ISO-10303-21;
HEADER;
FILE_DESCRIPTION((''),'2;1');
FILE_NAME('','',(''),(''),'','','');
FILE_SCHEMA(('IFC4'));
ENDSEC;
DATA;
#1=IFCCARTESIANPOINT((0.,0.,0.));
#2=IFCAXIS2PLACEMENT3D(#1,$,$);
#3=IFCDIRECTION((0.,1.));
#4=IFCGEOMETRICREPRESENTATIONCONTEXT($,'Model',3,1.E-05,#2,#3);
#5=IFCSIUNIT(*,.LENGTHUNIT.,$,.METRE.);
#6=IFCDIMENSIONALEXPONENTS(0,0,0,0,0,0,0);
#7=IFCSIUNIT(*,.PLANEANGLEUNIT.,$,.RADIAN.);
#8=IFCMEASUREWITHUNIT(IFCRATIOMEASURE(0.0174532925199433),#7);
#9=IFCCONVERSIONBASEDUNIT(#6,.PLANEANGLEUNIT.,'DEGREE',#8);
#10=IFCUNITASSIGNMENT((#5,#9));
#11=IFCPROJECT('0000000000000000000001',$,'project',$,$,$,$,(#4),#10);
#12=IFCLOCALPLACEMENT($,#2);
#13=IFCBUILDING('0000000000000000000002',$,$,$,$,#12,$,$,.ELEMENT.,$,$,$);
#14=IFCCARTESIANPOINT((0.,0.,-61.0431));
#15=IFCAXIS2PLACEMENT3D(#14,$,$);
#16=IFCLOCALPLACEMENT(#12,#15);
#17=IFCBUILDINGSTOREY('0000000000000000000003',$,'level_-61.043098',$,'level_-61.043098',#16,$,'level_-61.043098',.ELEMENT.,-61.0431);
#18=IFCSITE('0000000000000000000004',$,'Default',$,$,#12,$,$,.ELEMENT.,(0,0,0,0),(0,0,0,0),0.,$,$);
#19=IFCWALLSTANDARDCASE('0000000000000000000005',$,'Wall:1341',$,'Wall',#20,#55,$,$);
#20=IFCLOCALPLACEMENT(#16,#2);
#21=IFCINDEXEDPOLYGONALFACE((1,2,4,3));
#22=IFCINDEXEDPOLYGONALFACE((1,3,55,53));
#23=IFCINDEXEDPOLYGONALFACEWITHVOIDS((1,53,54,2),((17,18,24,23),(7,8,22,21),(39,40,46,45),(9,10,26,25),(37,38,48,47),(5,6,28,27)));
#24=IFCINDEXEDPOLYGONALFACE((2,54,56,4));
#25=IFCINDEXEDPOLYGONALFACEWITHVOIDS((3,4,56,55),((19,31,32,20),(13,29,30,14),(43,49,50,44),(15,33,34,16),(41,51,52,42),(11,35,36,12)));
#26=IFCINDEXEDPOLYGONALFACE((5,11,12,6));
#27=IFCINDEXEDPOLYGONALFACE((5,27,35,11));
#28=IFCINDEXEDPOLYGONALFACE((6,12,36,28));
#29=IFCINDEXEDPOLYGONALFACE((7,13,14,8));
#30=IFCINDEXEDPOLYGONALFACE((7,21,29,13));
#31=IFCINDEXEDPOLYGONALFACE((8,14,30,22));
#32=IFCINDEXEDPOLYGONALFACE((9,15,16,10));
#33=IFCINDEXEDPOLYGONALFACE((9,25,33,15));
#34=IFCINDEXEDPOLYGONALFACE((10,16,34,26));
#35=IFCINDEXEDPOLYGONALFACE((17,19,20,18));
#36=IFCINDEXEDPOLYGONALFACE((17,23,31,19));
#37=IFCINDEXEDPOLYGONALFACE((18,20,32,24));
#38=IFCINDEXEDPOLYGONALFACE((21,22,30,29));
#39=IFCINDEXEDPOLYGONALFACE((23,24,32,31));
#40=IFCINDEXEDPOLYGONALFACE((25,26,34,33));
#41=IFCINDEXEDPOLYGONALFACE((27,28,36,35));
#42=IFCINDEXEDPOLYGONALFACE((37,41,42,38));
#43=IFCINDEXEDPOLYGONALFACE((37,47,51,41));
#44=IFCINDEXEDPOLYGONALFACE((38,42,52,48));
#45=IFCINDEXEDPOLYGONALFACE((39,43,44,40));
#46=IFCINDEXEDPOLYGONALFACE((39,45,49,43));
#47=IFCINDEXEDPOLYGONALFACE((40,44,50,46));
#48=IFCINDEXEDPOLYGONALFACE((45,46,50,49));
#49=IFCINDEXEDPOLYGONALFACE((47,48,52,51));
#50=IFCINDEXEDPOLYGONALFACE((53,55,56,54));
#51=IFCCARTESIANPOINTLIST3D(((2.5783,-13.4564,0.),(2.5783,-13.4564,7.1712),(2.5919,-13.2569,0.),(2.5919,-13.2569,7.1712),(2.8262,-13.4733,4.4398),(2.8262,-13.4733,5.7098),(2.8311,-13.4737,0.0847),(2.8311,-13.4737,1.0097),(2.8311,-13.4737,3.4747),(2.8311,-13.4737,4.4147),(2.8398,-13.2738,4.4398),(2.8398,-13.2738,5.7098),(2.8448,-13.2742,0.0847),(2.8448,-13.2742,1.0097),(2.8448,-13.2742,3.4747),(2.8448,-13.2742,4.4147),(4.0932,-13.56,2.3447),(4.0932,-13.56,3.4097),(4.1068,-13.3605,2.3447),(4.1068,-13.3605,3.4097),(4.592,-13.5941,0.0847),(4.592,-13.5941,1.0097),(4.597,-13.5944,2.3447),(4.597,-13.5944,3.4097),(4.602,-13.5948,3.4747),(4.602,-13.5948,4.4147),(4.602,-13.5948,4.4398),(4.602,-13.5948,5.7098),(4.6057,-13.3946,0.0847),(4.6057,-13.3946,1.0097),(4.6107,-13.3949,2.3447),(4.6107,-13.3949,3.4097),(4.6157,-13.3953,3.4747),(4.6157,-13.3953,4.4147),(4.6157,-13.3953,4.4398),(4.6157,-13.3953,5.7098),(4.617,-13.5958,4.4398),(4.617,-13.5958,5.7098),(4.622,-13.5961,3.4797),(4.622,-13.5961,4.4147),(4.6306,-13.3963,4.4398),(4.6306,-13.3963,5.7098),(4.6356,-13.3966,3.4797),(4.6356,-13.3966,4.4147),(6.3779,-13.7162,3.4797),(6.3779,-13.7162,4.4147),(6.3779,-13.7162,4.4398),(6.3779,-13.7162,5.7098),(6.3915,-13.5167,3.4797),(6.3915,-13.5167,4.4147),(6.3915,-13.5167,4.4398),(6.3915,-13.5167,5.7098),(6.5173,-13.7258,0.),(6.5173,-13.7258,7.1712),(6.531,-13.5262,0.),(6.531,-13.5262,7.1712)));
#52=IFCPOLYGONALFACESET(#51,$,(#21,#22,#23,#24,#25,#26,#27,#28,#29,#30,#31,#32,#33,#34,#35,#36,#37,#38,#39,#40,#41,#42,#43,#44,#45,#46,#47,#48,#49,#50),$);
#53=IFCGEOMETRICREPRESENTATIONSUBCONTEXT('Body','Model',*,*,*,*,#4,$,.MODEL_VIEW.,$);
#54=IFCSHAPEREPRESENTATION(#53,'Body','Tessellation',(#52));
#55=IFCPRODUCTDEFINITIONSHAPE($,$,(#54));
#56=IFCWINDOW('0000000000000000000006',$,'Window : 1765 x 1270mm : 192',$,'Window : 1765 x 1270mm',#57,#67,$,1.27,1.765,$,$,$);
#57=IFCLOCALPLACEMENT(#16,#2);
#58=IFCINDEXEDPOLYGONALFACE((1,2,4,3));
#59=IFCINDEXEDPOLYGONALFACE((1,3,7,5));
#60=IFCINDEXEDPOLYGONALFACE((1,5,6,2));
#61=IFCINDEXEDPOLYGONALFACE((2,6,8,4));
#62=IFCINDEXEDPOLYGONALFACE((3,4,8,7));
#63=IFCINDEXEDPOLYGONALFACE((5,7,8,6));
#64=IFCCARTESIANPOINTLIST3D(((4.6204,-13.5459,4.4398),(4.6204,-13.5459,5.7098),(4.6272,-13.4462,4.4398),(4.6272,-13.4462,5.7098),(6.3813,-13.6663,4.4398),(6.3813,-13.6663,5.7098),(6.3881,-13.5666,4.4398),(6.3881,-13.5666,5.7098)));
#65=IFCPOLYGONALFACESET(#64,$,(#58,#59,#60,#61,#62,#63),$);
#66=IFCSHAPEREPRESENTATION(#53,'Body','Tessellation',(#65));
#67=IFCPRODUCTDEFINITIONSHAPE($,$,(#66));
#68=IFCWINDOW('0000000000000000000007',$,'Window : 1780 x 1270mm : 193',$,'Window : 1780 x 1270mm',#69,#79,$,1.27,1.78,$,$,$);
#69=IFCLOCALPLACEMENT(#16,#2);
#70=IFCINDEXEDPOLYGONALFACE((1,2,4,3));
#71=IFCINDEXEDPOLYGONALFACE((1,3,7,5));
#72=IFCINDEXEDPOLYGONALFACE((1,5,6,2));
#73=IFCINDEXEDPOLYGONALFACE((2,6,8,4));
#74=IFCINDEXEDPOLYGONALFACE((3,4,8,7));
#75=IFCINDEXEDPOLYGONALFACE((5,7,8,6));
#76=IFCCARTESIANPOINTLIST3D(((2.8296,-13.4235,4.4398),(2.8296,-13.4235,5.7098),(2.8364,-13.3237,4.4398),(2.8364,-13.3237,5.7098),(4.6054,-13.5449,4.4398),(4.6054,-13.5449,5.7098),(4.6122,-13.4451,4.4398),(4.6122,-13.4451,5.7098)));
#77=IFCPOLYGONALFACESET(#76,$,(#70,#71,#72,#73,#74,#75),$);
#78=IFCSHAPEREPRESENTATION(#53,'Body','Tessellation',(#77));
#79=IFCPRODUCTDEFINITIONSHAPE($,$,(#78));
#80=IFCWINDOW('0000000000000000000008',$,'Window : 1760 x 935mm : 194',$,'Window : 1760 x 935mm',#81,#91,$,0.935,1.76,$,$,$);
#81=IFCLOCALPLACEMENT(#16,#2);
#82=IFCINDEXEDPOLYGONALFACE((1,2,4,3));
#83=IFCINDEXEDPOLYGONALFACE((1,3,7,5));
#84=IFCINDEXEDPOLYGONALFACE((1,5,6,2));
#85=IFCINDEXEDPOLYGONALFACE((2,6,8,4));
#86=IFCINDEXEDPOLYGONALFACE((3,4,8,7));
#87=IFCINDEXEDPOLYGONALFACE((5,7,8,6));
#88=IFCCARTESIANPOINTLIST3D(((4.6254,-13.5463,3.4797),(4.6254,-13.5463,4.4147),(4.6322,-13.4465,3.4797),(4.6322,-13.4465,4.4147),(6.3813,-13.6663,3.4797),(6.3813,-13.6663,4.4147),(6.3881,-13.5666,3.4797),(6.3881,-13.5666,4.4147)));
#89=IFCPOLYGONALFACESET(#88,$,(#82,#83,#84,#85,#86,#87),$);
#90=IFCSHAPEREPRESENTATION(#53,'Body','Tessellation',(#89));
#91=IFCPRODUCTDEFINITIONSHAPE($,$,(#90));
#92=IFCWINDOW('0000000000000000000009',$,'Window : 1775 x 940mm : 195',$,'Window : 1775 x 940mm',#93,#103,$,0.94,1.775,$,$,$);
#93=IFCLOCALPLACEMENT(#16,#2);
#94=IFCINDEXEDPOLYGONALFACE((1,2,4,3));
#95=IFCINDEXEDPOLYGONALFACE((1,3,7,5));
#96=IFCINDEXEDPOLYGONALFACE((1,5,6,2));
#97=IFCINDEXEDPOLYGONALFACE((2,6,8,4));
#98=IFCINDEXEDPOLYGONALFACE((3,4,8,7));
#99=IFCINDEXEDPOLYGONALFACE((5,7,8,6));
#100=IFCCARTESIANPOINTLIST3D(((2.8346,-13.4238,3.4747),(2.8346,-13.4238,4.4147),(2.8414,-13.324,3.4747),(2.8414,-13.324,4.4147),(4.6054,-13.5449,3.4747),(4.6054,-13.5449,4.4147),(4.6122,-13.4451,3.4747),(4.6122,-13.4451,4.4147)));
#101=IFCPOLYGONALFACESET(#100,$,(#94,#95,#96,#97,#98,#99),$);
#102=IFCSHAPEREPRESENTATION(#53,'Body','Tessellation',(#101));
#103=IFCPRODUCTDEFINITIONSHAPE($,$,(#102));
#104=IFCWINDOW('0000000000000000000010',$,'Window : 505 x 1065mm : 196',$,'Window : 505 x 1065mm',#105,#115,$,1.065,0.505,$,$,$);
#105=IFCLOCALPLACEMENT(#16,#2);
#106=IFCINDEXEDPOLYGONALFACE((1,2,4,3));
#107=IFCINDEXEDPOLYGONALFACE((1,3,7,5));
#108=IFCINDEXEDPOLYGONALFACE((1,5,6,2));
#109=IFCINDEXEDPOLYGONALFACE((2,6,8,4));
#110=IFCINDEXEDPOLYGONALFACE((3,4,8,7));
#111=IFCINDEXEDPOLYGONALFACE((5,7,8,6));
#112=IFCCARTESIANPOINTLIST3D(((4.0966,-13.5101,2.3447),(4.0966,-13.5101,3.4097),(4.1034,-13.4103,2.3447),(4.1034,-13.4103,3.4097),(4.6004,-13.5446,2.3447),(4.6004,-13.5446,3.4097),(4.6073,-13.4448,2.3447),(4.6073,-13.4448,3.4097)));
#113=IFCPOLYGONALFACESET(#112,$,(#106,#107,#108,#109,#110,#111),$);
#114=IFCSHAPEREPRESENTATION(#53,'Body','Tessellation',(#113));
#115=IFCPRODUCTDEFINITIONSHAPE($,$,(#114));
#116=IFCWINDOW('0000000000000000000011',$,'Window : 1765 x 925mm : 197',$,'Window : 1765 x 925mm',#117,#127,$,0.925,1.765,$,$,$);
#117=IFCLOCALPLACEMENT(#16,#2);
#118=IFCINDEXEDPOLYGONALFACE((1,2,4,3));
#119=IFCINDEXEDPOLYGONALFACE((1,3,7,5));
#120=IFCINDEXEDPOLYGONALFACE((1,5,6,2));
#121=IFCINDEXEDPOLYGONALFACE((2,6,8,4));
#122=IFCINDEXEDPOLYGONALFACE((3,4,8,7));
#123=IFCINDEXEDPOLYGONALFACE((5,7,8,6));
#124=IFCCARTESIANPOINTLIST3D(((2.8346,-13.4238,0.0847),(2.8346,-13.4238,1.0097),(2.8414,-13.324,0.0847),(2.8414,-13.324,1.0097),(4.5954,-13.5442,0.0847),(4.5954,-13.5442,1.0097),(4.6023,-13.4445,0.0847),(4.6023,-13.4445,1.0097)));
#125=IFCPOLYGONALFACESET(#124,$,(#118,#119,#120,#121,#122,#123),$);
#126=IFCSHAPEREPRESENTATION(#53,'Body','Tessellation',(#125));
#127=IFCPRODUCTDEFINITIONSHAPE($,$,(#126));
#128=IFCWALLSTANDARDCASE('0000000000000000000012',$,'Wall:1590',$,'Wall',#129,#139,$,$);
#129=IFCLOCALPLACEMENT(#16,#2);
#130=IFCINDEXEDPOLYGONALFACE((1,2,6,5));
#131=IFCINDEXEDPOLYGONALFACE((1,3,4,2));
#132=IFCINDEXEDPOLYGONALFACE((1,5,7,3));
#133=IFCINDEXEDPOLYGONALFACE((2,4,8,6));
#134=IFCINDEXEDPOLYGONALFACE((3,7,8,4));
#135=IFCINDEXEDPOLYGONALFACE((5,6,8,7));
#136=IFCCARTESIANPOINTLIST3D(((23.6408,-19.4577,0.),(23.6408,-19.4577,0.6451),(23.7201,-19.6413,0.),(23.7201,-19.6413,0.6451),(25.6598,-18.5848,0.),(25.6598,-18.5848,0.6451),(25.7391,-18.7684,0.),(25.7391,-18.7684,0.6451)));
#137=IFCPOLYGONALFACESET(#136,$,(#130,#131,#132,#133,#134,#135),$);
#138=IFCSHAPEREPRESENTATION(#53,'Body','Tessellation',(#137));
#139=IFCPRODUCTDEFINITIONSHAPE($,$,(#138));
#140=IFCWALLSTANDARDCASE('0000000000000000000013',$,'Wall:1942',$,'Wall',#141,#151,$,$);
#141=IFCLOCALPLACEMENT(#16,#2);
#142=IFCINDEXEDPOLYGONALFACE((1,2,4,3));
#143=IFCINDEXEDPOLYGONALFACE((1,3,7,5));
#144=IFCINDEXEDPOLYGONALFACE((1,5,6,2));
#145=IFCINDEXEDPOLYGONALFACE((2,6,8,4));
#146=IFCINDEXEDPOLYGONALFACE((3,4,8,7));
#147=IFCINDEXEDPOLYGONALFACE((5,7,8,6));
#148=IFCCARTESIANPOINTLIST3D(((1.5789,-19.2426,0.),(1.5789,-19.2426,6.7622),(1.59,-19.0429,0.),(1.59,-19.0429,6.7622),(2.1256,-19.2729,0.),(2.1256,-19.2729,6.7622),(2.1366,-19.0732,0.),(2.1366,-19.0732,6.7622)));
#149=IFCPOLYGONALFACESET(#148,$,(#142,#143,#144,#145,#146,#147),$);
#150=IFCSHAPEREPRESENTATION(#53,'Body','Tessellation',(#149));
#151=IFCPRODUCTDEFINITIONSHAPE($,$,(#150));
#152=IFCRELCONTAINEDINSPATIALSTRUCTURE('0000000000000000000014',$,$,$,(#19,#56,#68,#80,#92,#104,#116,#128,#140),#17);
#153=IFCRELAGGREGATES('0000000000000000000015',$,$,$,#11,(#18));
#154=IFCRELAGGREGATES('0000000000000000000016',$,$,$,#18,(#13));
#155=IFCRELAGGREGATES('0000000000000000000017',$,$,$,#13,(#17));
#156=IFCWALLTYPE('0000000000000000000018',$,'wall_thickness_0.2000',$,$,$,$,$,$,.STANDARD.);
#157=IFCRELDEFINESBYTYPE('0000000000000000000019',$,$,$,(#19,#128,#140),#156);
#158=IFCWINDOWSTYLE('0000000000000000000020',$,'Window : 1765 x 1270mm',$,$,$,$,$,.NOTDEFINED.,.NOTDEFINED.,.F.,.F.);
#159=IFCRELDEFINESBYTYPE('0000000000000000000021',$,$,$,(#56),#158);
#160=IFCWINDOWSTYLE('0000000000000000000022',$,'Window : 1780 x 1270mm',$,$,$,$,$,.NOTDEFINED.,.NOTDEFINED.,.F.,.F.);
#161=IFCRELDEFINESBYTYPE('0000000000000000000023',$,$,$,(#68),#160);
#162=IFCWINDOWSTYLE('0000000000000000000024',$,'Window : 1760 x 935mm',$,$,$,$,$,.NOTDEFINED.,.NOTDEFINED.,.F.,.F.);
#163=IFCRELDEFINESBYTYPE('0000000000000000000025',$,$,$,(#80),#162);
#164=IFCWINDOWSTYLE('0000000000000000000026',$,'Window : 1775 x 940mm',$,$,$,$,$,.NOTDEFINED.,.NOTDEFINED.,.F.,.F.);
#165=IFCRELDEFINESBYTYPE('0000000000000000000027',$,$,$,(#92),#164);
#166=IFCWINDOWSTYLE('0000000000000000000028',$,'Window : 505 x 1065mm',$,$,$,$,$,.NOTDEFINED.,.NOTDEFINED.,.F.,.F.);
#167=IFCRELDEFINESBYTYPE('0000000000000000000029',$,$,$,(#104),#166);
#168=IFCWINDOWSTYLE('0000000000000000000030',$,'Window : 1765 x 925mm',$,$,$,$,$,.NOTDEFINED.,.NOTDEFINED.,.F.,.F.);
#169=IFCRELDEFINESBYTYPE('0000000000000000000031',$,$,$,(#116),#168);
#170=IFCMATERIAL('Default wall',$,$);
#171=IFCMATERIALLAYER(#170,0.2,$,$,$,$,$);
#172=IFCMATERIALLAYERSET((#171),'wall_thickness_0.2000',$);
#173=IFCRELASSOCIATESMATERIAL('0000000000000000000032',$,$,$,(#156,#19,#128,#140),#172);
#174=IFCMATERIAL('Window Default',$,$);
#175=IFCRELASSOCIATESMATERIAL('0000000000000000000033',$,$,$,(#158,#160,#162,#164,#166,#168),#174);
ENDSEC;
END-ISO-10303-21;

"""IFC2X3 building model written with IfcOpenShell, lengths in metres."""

from ifc_helpers import new_model, entity, si_unit, converted_unit, direction, frame, frame_2d, origin, origin_2d_with_axis, place, context, subcontext, project, spatial, polyline, rectangle, outline, extrude, source, transform, mapped, material, layer, layer_set, layer_usage, type_object, type_shapes, element, fill, save


model = new_model("IFC2X3")

# Units and contexts
model_context = context("Model", 3, precision=1e-05, world=origin(), true_north=direction((0.0, 1.0)))
body_context = subcontext(model_context, "Body", "Model", "MODEL_VIEW")
ifc_project = project(units=[si_unit("LENGTHUNIT", "METRE"), converted_unit("PLANEANGLEUNIT", "DEGREE", entity("IfcRatioMeasure", 0.0174532925199433), si_unit("PLANEANGLEUNIT", "RADIAN"), dimensions=[0, 0, 0, 0, 0, 0, 0])], contexts=[model_context])

# Site, building, storey
placement_1 = place(None, origin())
site = spatial("IfcSite", under=ifc_project, at=placement_1, Name="Default", CompositionType="ELEMENT", RefLatitude=(0, 0, 0, 0), RefLongitude=(0, 0, 0, 0), RefElevation=0.0)
building = spatial("IfcBuilding", under=site, at=placement_1, CompositionType="ELEMENT")
storey_placement = place(placement_1, frame((0.0, 0.0, -61.0431)))
storey = spatial("IfcBuildingStorey", under=building, at=storey_placement, Name="level_-61.043098", ObjectType="level_-61.043098", LongName="level_-61.043098", CompositionType="ELEMENT", Elevation=-61.0431)

# Shared definitions
ifc_material_1 = material(Name="Default wall")
ifc_layer = layer(ifc_material_1, 0.2)
ifc_layer_set = layer_set([ifc_layer], Name="wall_thickness_0.2000")
ifc_layer_usage = layer_usage(ifc_layer_set, "AXIS2", "POSITIVE", -0.1)
wall_type = type_object("IfcWallType", Name="wall_thickness_0.2000", PredefinedType="STANDARD", material=ifc_layer_set)

# Shared definitions
ifc_material_2 = material(Name="Window Default")

# Wall, openings, windows
wall_1_placement = place(storey_placement, frame((6.5241, -13.626, 0.0), z_axis=(0.0, 0.0, 1.0), x_axis=(-0.99767, 0.068223, 0.0)))
wall_1 = element("IfcWallStandardCase", 1, at=wall_1_placement, inside=storey, type_object=wall_type, material=ifc_layer_usage, Name="Wall:1341", ObjectType="Wall", context=body_context, shape_type="SweptSolid", body=[
    extrude(outline(polyline([(3.9482, -0.1), (3.9482, 0.1), (0.0, 0.1), (0.0, -0.1), (3.9482, -0.1)])), origin(), (0.0, 0.0, 1.0), 7.1712),
])
opening_1_placement = place(wall_1_placement, frame((0.1398, -0.1, 4.4398)))
opening_1 = element("IfcOpeningElement", 2, at=opening_1_placement, cuts=wall_1, ObjectType="Opening", context=body_context, shape_type="SweptSolid", body=[
    extrude(rectangle(XDim=1.765, YDim=1.27, at=frame_2d((0.635, 0.8825), x_axis=(0.0, 1.0))), frame((0.0, 0.0, 0.0), z_axis=(0.0, 1.0, 0.0), x_axis=(0.0, 0.0, 1.0)), (0.0, 0.0, 1.0), 0.2),
])
opening_2_placement = place(wall_1_placement, frame((1.9198, -0.1, 4.4398)))
opening_2 = element("IfcOpeningElement", 3, at=opening_2_placement, cuts=wall_1, ObjectType="Opening", context=body_context, shape_type="SweptSolid", body=[
    extrude(rectangle(XDim=1.78, YDim=1.27, at=frame_2d((0.635, 0.89), x_axis=(0.0, 1.0))), frame((0.0, 0.0, 0.0), z_axis=(0.0, 1.0, 0.0), x_axis=(0.0, 0.0, 1.0)), (0.0, 0.0, 1.0), 0.2),
])
opening_3_placement = place(wall_1_placement, frame((0.1398, -0.1, 3.4797)))
opening_3 = element("IfcOpeningElement", 4, at=opening_3_placement, cuts=wall_1, ObjectType="Opening", context=body_context, shape_type="SweptSolid", body=[
    extrude(rectangle(XDim=1.76, YDim=0.935, at=frame_2d((0.4675, 0.88), x_axis=(0.0, 1.0))), frame((0.0, 0.0, 0.0), z_axis=(0.0, 1.0, 0.0), x_axis=(0.0, 0.0, 1.0)), (0.0, 0.0, 1.0), 0.2),
])
opening_4_placement = place(wall_1_placement, frame((1.9198, -0.1, 3.4747)))
opening_4 = element("IfcOpeningElement", 5, at=opening_4_placement, cuts=wall_1, ObjectType="Opening", context=body_context, shape_type="SweptSolid", body=[
    extrude(rectangle(XDim=1.775, YDim=0.94, at=frame_2d((0.47, 0.8875), x_axis=(0.0, 1.0))), frame((0.0, 0.0, 0.0), z_axis=(0.0, 1.0, 0.0), x_axis=(0.0, 0.0, 1.0)), (0.0, 0.0, 1.0), 0.2),
])
opening_5_placement = place(wall_1_placement, frame((1.9248, -0.1, 2.3447)))
opening_5 = element("IfcOpeningElement", 6, at=opening_5_placement, cuts=wall_1, ObjectType="Opening", context=body_context, shape_type="SweptSolid", body=[
    extrude(rectangle(XDim=0.505, YDim=1.065, at=frame_2d((0.5325, 0.2525), x_axis=(0.0, 1.0))), frame((0.0, 0.0, 0.0), z_axis=(0.0, 1.0, 0.0), x_axis=(0.0, 0.0, 1.0)), (0.0, 0.0, 1.0), 0.2),
])
opening_6_placement = place(wall_1_placement, frame((1.9298, -0.1, 0.0847)))
opening_6 = element("IfcOpeningElement", 7, at=opening_6_placement, cuts=wall_1, ObjectType="Opening", context=body_context, shape_type="SweptSolid", body=[
    extrude(rectangle(XDim=1.765, YDim=0.925, at=frame_2d((0.4625, 0.8825), x_axis=(0.0, 1.0))), frame((0.0, 0.0, 0.0), z_axis=(0.0, 1.0, 0.0), x_axis=(0.0, 0.0, 1.0)), (0.0, 0.0, 1.0), 0.2),
])
window_style_1 = type_object("IfcWindowStyle", Name="Window : 1765 x 1270mm", ConstructionType="NOTDEFINED", OperationType="NOTDEFINED", ParameterTakesPrecedence=False, Sizeable=False, material=ifc_material_2)
shared_shape_1 = source(origin(), body_context, "Body", "SweptSolid", [
    extrude(rectangle(XDim=0.1, YDim=1.765, at=origin_2d_with_axis()), frame((0.8825, 0.1, 0.0), z_axis=(0.0, 0.0, 1.0), x_axis=(0.0, 1.0, 0.0)), (0.0, 0.0, 1.0), 1.27),
])
type_shapes(window_style_1, [shared_shape_1])
window_1_placement = place(opening_1_placement, origin())
window_1 = element("IfcWindow", 8, at=window_1_placement, inside=storey, type_object=window_style_1, Name="Window : 1765 x 1270mm : 192", ObjectType="Window : 1765 x 1270mm", OverallHeight=1.27, OverallWidth=1.765, context=body_context, shape_type="MappedRepresentation", body=[
    mapped(shared_shape_1, transform((0.0, 0.0, 0.0), scale=1.0)),
])
fill(opening_1, window_1)
window_style_2 = type_object("IfcWindowStyle", Name="Window : 1780 x 1270mm", ConstructionType="NOTDEFINED", OperationType="NOTDEFINED", ParameterTakesPrecedence=False, Sizeable=False, material=ifc_material_2)
shared_shape_2 = source(origin(), body_context, "Body", "SweptSolid", [
    extrude(rectangle(XDim=0.1, YDim=1.78, at=origin_2d_with_axis()), frame((0.89, 0.1, 0.0), z_axis=(0.0, 0.0, 1.0), x_axis=(0.0, 1.0, 0.0)), (0.0, 0.0, 1.0), 1.27),
])
type_shapes(window_style_2, [shared_shape_2])
window_2_placement = place(opening_2_placement, origin())
window_2 = element("IfcWindow", 9, at=window_2_placement, inside=storey, type_object=window_style_2, Name="Window : 1780 x 1270mm : 193", ObjectType="Window : 1780 x 1270mm", OverallHeight=1.27, OverallWidth=1.78, context=body_context, shape_type="MappedRepresentation", body=[
    mapped(shared_shape_2, transform((0.0, 0.0, 0.0), scale=1.0)),
])
fill(opening_2, window_2)
window_style_3 = type_object("IfcWindowStyle", Name="Window : 1760 x 935mm", ConstructionType="NOTDEFINED", OperationType="NOTDEFINED", ParameterTakesPrecedence=False, Sizeable=False, material=ifc_material_2)
shared_shape_3 = source(origin(), body_context, "Body", "SweptSolid", [
    extrude(rectangle(XDim=0.1, YDim=1.76, at=origin_2d_with_axis()), frame((0.88, 0.1, 0.0), z_axis=(0.0, 0.0, 1.0), x_axis=(0.0, 1.0, 0.0)), (0.0, 0.0, 1.0), 0.935),
])
type_shapes(window_style_3, [shared_shape_3])
window_3_placement = place(opening_3_placement, origin())
window_3 = element("IfcWindow", 10, at=window_3_placement, inside=storey, type_object=window_style_3, Name="Window : 1760 x 935mm : 194", ObjectType="Window : 1760 x 935mm", OverallHeight=0.935, OverallWidth=1.76, context=body_context, shape_type="MappedRepresentation", body=[
    mapped(shared_shape_3, transform((0.0, 0.0, 0.0), scale=1.0)),
])
fill(opening_3, window_3)
window_style_4 = type_object("IfcWindowStyle", Name="Window : 1775 x 940mm", ConstructionType="NOTDEFINED", OperationType="NOTDEFINED", ParameterTakesPrecedence=False, Sizeable=False, material=ifc_material_2)
shared_shape_4 = source(origin(), body_context, "Body", "SweptSolid", [
    extrude(rectangle(XDim=0.1, YDim=1.775, at=origin_2d_with_axis()), frame((0.8875, 0.1, 0.0), z_axis=(0.0, 0.0, 1.0), x_axis=(0.0, 1.0, 0.0)), (0.0, 0.0, 1.0), 0.94),
])
type_shapes(window_style_4, [shared_shape_4])
window_4_placement = place(opening_4_placement, origin())
window_4 = element("IfcWindow", 11, at=window_4_placement, inside=storey, type_object=window_style_4, Name="Window : 1775 x 940mm : 195", ObjectType="Window : 1775 x 940mm", OverallHeight=0.94, OverallWidth=1.775, context=body_context, shape_type="MappedRepresentation", body=[
    mapped(shared_shape_4, transform((0.0, 0.0, 0.0), scale=1.0)),
])
fill(opening_4, window_4)
window_style_5 = type_object("IfcWindowStyle", Name="Window : 505 x 1065mm", ConstructionType="NOTDEFINED", OperationType="NOTDEFINED", ParameterTakesPrecedence=False, Sizeable=False, material=ifc_material_2)
shared_shape_5 = source(origin(), body_context, "Body", "SweptSolid", [
    extrude(rectangle(XDim=0.1, YDim=0.505, at=origin_2d_with_axis()), frame((0.2525, 0.1, 0.0), z_axis=(0.0, 0.0, 1.0), x_axis=(0.0, 1.0, 0.0)), (0.0, 0.0, 1.0), 1.065),
])
type_shapes(window_style_5, [shared_shape_5])
window_5_placement = place(opening_5_placement, origin())
window_5 = element("IfcWindow", 12, at=window_5_placement, inside=storey, type_object=window_style_5, Name="Window : 505 x 1065mm : 196", ObjectType="Window : 505 x 1065mm", OverallHeight=1.065, OverallWidth=0.505, context=body_context, shape_type="MappedRepresentation", body=[
    mapped(shared_shape_5, transform((0.0, 0.0, 0.0), scale=1.0)),
])
fill(opening_5, window_5)
window_style_6 = type_object("IfcWindowStyle", Name="Window : 1765 x 925mm", ConstructionType="NOTDEFINED", OperationType="NOTDEFINED", ParameterTakesPrecedence=False, Sizeable=False, material=ifc_material_2)
shared_shape_6 = source(origin(), body_context, "Body", "SweptSolid", [
    extrude(rectangle(XDim=0.1, YDim=1.765, at=origin_2d_with_axis()), frame((0.8825, 0.1, 0.0), z_axis=(0.0, 0.0, 1.0), x_axis=(0.0, 1.0, 0.0)), (0.0, 0.0, 1.0), 0.925),
])
type_shapes(window_style_6, [shared_shape_6])
window_6_placement = place(opening_6_placement, origin())
window_6 = element("IfcWindow", 13, at=window_6_placement, inside=storey, type_object=window_style_6, Name="Window : 1765 x 925mm : 197", ObjectType="Window : 1765 x 925mm", OverallHeight=0.925, OverallWidth=1.765, context=body_context, shape_type="MappedRepresentation", body=[
    mapped(shared_shape_6, transform((0.0, 0.0, 0.0), scale=1.0)),
])
fill(opening_6, window_6)

# Walls
wall_2_placement = place(storey_placement, frame((23.6804, -19.5495, 0.0), z_axis=(0.0, 0.0, 1.0), x_axis=(0.917895, 0.396824, 0.0)))
element("IfcWallStandardCase", 14, at=wall_2_placement, inside=storey, type_object=wall_type, material=ifc_layer_usage, Name="Wall:1590", ObjectType="Wall", context=body_context, shape_type="SweptSolid", body=[
    extrude(outline(polyline([(2.1996, -0.1), (2.1996, 0.1), (0.0, 0.1), (0.0, -0.1), (2.1996, -0.1)])), origin(), (0.0, 0.0, 1.0), 0.6451),
])
wall_3_placement = place(storey_placement, frame((2.1311, -19.1731, 0.0), z_axis=(0.0, 0.0, 1.0), x_axis=(-0.998463, 0.055425, 0.0)))
element("IfcWallStandardCase", 15, at=wall_3_placement, inside=storey, type_object=wall_type, material=ifc_layer_usage, Name="Wall:1942", ObjectType="Wall", context=body_context, shape_type="SweptSolid", body=[
    extrude(outline(polyline([(0.5475, -0.1), (0.5475, 0.1), (0.0, 0.1), (0.0, -0.1), (0.5475, -0.1)])), origin(), (0.0, 0.0, 1.0), 6.7622),
])

save(model, "model.ifc")
